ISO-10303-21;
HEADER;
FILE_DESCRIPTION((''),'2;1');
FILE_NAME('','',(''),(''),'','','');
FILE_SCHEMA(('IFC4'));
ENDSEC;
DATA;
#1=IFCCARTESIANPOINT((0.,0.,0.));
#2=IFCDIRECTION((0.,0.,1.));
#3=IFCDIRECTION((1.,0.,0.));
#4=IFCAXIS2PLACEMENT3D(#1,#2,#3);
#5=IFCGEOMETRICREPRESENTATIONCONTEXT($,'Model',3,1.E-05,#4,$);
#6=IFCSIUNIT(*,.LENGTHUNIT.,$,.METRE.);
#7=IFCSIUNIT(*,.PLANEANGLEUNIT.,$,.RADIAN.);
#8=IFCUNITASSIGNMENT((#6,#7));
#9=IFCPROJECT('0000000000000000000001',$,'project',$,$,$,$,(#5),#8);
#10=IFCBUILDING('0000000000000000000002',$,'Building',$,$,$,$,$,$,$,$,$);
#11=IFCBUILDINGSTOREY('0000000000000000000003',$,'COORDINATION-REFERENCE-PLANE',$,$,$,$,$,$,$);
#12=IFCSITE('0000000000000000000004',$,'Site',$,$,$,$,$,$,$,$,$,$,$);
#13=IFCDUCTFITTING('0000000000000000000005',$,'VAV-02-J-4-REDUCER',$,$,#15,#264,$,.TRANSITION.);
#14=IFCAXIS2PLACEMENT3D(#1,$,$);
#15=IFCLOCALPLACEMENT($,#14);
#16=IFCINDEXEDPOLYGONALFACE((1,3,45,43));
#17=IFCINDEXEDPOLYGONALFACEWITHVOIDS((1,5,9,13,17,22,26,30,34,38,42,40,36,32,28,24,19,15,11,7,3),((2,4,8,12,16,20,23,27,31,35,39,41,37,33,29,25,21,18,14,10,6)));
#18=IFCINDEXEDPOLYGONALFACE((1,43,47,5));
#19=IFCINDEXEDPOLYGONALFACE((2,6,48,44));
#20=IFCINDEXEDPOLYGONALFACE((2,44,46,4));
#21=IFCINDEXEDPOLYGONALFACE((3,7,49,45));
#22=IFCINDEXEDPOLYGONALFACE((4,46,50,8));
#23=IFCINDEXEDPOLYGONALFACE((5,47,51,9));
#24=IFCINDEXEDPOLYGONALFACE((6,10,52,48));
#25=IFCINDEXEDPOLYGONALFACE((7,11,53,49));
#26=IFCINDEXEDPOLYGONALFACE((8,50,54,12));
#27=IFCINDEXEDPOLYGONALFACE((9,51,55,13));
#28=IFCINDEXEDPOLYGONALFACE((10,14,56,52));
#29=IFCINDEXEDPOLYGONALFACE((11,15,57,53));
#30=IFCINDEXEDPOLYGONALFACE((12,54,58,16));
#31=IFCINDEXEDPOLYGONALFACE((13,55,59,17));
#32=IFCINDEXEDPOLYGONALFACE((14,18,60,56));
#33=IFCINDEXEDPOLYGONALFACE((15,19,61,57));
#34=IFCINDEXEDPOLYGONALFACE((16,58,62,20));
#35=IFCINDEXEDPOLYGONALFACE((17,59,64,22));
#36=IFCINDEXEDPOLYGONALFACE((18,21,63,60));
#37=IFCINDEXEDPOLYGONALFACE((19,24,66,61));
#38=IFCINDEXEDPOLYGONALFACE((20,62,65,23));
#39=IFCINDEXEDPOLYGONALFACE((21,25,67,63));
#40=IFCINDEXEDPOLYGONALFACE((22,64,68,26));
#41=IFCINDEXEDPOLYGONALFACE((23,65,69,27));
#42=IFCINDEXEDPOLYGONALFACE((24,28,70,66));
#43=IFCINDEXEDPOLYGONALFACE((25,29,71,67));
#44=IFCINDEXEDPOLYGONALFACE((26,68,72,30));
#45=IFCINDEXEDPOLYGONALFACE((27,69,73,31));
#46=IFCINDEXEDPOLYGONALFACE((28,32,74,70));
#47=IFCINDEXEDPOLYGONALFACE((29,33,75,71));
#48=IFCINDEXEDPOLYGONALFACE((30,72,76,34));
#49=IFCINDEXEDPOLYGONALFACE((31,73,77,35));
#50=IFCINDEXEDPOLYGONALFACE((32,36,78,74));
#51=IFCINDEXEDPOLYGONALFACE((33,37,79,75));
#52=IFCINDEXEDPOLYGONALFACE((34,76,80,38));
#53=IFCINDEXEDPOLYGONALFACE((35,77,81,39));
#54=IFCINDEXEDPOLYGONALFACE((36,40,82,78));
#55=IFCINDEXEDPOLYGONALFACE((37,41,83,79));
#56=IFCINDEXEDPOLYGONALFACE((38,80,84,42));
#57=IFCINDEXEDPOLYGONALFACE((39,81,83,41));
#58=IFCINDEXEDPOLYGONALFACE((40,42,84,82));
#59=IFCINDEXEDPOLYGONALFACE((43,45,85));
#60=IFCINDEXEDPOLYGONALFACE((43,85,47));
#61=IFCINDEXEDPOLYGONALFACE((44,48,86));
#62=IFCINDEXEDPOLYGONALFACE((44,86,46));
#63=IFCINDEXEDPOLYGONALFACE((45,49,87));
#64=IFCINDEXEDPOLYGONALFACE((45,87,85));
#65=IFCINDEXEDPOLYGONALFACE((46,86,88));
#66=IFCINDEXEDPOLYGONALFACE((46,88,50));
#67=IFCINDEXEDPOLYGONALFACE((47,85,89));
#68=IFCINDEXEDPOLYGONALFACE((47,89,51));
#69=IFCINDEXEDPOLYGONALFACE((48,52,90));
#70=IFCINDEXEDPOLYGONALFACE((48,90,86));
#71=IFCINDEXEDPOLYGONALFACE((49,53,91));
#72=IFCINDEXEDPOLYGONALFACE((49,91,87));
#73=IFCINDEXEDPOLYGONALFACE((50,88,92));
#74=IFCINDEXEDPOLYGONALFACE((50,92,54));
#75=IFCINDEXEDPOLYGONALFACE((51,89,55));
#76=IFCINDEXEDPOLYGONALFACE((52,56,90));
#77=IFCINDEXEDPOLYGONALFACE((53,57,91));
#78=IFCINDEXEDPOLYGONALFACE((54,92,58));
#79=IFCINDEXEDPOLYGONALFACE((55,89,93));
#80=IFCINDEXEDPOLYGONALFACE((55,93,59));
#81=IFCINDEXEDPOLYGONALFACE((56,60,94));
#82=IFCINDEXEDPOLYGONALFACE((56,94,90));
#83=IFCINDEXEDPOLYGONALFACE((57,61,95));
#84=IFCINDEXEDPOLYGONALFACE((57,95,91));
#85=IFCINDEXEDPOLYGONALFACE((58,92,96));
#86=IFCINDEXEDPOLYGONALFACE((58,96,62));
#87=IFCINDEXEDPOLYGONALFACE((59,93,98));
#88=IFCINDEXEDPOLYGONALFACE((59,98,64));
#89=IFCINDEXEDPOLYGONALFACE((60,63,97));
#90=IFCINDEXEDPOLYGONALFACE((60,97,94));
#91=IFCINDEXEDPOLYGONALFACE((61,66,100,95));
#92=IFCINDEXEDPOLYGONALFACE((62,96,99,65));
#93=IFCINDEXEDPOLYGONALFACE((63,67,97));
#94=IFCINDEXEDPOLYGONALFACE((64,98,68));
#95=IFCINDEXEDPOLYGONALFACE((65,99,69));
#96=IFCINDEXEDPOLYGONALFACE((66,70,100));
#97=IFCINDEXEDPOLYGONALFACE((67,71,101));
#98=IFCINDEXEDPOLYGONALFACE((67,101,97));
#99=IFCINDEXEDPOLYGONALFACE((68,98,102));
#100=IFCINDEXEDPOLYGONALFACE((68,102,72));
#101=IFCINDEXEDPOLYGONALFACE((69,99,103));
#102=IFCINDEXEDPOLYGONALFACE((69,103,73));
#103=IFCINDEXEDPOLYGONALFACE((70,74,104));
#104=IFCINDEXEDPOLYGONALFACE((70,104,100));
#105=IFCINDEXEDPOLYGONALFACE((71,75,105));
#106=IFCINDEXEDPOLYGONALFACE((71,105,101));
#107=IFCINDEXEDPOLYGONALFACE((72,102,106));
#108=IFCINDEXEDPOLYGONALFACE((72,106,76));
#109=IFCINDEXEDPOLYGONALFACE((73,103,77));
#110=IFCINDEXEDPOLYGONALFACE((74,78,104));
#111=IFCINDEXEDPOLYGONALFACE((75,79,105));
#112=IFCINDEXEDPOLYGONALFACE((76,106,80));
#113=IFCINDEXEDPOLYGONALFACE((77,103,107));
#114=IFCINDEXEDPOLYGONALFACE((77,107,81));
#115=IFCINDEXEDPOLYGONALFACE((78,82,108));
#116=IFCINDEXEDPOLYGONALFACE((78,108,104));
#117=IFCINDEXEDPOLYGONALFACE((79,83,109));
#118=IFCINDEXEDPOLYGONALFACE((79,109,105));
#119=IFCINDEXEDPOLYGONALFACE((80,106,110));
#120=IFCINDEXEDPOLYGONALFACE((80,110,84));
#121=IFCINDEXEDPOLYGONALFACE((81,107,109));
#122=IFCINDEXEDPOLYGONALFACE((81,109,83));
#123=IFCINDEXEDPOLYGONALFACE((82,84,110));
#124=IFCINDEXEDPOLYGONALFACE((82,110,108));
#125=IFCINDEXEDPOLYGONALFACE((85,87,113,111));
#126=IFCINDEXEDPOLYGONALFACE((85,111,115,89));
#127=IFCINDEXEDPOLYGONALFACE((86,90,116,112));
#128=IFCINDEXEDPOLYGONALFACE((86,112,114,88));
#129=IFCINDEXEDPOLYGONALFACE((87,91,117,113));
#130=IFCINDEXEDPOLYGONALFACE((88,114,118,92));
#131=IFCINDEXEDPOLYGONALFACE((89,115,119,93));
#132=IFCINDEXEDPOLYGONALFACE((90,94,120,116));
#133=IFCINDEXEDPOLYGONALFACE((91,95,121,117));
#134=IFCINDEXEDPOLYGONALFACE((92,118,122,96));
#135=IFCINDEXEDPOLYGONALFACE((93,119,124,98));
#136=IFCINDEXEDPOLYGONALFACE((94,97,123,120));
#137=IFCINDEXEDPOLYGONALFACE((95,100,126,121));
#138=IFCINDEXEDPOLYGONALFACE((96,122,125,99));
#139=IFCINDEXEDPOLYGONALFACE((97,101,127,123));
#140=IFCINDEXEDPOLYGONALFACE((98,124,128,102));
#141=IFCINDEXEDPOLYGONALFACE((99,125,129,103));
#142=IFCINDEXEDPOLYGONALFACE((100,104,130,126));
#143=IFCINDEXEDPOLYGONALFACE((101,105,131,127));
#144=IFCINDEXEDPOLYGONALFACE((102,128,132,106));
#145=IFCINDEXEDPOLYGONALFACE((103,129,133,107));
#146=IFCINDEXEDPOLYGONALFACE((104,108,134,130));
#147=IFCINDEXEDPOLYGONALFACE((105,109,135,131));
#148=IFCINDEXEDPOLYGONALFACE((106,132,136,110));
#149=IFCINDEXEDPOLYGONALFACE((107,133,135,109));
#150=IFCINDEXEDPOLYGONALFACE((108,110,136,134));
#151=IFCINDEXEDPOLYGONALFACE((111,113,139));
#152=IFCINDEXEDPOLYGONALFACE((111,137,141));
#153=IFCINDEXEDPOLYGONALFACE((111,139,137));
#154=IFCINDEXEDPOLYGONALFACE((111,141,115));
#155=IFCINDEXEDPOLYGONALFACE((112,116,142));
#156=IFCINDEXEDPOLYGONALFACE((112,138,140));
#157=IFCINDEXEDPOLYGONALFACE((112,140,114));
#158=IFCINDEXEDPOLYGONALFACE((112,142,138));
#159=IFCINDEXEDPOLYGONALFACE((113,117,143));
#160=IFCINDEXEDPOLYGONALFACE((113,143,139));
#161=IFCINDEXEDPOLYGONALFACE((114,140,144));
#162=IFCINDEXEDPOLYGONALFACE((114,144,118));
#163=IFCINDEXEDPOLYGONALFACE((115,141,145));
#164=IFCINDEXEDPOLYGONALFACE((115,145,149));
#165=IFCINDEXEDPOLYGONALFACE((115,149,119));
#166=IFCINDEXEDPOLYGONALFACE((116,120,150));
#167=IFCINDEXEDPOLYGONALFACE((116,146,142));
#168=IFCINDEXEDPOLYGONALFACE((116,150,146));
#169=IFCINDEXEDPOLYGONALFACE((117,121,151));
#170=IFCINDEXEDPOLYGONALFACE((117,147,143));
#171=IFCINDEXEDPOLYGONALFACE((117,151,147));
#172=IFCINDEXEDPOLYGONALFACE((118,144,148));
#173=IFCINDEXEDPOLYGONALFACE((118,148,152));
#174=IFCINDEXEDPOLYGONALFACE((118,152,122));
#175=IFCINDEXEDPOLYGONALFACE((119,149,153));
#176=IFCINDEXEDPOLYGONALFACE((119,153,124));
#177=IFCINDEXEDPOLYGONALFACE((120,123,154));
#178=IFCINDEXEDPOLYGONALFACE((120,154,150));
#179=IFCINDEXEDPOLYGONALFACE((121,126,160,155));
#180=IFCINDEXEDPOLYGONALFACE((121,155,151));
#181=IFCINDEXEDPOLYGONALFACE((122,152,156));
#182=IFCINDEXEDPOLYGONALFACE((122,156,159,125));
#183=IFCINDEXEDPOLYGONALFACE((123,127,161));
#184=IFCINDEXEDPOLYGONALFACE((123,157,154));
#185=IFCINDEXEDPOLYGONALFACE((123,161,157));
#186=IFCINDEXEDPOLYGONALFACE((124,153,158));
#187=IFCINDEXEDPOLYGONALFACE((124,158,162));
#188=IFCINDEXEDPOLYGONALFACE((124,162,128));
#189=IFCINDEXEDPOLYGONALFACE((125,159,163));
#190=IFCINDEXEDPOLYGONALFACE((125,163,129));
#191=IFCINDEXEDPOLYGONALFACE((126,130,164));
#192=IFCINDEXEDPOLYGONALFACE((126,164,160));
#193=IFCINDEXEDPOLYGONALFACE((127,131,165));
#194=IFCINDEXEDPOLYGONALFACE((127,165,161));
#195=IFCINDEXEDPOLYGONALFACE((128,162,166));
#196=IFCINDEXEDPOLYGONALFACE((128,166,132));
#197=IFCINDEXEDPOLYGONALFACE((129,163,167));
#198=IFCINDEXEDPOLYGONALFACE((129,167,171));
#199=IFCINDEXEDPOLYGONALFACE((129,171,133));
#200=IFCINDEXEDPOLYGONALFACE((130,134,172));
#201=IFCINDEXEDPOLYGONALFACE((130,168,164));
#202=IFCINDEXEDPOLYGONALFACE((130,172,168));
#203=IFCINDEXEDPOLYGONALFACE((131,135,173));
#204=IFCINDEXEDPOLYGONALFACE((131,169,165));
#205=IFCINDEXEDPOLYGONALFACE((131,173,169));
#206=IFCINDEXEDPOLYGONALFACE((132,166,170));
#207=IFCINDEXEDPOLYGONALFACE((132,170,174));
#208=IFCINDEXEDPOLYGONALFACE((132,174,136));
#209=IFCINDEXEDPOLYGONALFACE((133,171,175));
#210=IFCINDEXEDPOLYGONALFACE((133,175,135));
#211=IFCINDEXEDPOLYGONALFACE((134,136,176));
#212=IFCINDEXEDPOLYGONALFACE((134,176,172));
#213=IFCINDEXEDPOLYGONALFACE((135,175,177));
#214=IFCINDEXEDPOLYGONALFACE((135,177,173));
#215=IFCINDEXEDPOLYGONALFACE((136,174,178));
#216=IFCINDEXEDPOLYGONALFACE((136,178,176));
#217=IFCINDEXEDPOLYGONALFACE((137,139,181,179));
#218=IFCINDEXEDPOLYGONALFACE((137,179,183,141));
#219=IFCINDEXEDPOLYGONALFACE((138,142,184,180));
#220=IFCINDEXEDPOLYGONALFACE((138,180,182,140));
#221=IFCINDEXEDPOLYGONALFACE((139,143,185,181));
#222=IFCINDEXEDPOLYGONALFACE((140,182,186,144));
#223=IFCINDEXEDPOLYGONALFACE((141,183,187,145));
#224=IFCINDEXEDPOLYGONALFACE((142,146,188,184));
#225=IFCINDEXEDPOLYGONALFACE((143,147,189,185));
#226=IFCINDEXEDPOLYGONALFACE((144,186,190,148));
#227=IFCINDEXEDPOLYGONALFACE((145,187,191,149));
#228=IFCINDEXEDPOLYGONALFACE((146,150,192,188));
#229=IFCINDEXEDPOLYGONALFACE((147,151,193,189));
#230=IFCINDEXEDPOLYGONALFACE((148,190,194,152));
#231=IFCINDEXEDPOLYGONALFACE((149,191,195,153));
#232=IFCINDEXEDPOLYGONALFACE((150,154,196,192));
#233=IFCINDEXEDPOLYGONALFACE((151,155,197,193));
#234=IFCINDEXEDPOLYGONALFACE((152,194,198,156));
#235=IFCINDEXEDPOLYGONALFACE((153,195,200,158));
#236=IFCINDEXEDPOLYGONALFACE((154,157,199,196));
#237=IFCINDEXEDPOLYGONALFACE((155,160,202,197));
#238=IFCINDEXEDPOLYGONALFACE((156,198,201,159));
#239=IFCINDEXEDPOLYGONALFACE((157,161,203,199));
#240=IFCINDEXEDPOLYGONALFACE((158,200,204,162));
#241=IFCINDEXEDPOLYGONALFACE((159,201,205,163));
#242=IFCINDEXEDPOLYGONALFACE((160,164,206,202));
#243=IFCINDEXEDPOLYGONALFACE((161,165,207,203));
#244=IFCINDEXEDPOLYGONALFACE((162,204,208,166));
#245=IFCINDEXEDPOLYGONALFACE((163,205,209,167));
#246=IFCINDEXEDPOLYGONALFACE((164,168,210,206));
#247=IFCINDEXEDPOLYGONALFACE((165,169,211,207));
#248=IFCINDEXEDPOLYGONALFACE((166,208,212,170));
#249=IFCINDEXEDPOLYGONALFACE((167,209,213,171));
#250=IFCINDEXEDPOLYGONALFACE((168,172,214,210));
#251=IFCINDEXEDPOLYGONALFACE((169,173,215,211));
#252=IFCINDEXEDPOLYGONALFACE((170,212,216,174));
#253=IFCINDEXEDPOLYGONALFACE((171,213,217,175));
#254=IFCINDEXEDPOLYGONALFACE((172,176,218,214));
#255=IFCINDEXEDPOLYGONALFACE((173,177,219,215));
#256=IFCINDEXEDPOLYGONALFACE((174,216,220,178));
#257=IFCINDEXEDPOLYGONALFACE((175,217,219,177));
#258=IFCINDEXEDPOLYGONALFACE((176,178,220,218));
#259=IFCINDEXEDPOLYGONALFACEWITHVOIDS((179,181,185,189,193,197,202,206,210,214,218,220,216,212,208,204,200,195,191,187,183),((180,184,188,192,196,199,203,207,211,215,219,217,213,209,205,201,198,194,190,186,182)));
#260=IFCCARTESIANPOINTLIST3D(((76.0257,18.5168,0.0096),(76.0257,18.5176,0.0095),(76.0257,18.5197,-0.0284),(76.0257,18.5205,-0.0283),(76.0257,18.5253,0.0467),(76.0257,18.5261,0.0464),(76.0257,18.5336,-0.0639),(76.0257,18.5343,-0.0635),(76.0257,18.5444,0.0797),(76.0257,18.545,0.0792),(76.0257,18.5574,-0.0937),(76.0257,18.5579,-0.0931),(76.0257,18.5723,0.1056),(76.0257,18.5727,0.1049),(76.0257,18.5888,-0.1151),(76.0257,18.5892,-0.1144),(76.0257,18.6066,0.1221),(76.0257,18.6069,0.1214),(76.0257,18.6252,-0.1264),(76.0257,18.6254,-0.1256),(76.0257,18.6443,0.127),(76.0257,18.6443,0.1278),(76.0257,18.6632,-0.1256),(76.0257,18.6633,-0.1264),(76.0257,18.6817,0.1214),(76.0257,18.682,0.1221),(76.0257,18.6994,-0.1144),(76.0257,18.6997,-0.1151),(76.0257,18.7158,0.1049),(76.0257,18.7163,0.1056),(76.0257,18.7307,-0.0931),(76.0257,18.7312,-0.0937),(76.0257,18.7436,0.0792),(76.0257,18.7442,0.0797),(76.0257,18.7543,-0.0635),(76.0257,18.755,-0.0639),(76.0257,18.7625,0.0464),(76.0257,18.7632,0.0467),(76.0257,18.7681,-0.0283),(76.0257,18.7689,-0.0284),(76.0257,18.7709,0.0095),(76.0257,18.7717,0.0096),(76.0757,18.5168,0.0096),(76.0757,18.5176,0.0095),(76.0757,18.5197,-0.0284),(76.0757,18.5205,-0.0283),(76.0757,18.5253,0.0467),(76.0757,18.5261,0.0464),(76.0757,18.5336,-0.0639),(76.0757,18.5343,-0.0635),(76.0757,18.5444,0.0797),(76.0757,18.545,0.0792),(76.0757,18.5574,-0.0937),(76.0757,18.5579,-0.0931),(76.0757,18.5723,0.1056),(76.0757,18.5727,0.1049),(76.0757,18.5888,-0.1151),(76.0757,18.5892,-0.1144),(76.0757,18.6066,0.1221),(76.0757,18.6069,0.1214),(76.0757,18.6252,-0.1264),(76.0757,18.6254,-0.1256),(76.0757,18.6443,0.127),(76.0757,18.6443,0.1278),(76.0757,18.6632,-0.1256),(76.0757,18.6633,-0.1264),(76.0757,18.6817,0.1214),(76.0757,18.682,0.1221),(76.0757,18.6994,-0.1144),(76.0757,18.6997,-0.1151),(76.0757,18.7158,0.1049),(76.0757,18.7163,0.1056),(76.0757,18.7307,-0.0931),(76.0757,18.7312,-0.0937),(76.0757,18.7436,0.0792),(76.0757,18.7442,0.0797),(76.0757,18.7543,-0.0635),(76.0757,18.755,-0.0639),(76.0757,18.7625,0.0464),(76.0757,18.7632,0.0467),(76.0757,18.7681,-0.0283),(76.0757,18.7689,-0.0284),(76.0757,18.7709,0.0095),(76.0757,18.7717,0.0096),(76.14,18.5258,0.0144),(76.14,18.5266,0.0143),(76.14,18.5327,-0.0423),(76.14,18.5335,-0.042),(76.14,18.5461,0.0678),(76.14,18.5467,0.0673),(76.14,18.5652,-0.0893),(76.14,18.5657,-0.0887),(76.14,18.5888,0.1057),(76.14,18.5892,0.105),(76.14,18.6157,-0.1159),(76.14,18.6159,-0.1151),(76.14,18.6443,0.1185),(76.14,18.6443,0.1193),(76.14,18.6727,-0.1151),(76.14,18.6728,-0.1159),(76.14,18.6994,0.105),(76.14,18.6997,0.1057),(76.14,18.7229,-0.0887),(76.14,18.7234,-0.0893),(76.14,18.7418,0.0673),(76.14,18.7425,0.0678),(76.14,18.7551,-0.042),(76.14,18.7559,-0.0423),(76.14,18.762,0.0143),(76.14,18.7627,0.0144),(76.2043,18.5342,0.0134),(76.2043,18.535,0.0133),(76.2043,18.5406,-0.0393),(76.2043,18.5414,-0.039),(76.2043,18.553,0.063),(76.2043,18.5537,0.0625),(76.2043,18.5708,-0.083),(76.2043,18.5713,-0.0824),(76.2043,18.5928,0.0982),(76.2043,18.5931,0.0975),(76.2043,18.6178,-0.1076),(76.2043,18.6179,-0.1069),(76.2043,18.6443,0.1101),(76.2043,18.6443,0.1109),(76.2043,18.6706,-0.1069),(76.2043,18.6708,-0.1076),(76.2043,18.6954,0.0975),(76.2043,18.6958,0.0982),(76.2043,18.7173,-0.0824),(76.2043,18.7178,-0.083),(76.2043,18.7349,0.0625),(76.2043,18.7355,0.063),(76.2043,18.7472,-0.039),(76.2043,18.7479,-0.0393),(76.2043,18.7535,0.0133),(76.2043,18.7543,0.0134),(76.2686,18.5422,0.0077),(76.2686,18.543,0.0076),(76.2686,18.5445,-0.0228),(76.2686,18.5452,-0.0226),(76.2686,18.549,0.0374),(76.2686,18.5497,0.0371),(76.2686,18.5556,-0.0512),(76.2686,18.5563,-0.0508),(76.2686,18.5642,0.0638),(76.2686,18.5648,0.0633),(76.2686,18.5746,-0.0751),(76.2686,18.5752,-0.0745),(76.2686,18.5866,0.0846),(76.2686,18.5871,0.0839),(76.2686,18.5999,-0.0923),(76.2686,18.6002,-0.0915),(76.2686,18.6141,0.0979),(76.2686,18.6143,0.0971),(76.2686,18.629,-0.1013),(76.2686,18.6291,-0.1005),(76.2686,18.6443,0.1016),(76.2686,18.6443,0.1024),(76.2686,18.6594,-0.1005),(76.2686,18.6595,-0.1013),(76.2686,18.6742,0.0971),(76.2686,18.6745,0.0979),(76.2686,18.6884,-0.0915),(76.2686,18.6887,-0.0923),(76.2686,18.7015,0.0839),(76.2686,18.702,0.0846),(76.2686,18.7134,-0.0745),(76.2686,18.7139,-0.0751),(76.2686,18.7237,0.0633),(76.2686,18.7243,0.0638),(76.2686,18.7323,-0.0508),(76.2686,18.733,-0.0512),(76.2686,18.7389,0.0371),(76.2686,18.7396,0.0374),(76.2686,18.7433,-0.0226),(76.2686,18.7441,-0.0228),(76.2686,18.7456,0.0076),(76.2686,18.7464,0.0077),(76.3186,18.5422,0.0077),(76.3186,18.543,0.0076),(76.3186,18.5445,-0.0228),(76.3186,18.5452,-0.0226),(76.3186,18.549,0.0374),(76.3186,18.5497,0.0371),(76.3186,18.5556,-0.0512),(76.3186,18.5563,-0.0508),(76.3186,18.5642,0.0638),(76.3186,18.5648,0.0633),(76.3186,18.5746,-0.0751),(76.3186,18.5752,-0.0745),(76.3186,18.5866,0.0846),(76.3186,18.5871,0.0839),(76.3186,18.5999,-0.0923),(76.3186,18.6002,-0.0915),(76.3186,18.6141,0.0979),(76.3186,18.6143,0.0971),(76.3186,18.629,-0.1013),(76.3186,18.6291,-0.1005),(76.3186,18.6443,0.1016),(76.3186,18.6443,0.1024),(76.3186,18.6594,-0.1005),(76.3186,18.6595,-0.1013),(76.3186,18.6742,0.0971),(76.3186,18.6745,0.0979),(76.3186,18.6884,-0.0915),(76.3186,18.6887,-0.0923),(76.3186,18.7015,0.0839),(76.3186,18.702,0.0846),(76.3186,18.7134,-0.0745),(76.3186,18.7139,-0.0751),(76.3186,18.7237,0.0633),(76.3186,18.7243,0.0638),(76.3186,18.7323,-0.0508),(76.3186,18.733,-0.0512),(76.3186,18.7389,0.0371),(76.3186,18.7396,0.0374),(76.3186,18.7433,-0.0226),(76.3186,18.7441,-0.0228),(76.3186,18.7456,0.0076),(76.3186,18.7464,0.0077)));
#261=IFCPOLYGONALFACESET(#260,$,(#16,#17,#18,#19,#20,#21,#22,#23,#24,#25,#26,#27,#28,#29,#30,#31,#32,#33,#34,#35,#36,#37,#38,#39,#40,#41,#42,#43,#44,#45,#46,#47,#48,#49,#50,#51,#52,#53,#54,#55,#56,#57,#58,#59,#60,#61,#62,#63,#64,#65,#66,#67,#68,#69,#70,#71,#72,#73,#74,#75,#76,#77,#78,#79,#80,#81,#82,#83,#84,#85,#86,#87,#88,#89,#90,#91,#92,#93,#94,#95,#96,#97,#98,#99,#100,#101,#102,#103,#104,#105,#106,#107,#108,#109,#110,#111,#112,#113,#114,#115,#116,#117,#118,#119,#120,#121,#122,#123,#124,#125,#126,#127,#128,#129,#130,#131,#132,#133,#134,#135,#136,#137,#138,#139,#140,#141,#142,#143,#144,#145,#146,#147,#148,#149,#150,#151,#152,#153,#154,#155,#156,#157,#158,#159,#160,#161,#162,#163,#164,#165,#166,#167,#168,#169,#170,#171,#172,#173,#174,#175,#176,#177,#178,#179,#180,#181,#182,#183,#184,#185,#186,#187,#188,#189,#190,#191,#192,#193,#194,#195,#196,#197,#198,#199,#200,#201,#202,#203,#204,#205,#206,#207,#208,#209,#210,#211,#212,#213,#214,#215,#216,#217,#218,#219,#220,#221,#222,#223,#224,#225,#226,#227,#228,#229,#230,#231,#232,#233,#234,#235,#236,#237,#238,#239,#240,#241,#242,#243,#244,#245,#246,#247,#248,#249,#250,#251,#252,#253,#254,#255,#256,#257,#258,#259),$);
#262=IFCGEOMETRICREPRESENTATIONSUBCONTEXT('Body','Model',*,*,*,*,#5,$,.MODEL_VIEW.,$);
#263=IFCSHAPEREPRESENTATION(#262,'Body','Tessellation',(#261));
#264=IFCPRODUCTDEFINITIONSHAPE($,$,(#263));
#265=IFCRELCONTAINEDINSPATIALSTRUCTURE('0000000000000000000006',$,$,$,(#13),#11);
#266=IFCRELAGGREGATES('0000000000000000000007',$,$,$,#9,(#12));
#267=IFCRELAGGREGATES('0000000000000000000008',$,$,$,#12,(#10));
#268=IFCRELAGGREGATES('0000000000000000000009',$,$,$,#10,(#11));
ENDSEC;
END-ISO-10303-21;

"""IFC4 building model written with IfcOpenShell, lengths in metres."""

from ifc_helpers import new_model, entity, si_unit, frame, origin_with_axes, place, context, subcontext, project, spatial, element, save


model = new_model("IFC4")

# Units and contexts
model_context_1 = context("Model", 3, precision=1e-05, world=origin_with_axes())
body_context_1 = subcontext(model_context_1, "Body", "Model", "MODEL_VIEW")
ifc_project = project(units=[si_unit("LENGTHUNIT", "METRE"), si_unit("PLANEANGLEUNIT", "RADIAN")], contexts=[model_context_1])

# Site, building, storey
site = spatial("IfcSite", under=ifc_project, Name="Site")
building = spatial("IfcBuilding", under=site, Name="Building")
storey = spatial("IfcBuildingStorey", under=building, Name="COORDINATION-REFERENCE-PLANE")

# Duct fitting
for number, where, z_axis, x_axis, name in (
    (1, (76.0257, 18.6443, 0.0), (0.0, 1.0, 0.0), (0.0, 0.0, 1.0), "VAV-02-J-4-REDUCER"),
):
    element("IfcDuctFitting", number, at=place(None, frame(where, z_axis=z_axis, x_axis=x_axis)), inside=storey, Name=name, PredefinedType="TRANSITION", context=body_context_1, shape_type="SweptSolid", body=[
        entity("IfcRevolvedAreaSolid", entity("IfcArbitraryClosedProfileDef", "AREA", None, entity("IfcPolyline", [entity("IfcCartesianPoint", [0.1278, 0.0]), entity("IfcCartesianPoint", [0.1278, 0.05]), entity("IfcCartesianPoint", [0.1024, 0.2429]), entity("IfcCartesianPoint", [0.1024, 0.2929]), entity("IfcCartesianPoint", [0.1016, 0.2929]), entity("IfcCartesianPoint", [0.1016, 0.2429]), entity("IfcCartesianPoint", [0.127, 0.05]), entity("IfcCartesianPoint", [0.127, 0.0]), entity("IfcCartesianPoint", [0.1278, 0.0])])), entity("IfcAxis2Placement3D", entity("IfcCartesianPoint", [0.0, 0.0, 0.0])), entity("IfcAxis1Placement", entity("IfcCartesianPoint", [0.0, 0.0, 0.0]), entity("IfcDirection", [0.0, 1.0, 0.0])), 6.283185),
    ])

save(model, "model.ifc")
